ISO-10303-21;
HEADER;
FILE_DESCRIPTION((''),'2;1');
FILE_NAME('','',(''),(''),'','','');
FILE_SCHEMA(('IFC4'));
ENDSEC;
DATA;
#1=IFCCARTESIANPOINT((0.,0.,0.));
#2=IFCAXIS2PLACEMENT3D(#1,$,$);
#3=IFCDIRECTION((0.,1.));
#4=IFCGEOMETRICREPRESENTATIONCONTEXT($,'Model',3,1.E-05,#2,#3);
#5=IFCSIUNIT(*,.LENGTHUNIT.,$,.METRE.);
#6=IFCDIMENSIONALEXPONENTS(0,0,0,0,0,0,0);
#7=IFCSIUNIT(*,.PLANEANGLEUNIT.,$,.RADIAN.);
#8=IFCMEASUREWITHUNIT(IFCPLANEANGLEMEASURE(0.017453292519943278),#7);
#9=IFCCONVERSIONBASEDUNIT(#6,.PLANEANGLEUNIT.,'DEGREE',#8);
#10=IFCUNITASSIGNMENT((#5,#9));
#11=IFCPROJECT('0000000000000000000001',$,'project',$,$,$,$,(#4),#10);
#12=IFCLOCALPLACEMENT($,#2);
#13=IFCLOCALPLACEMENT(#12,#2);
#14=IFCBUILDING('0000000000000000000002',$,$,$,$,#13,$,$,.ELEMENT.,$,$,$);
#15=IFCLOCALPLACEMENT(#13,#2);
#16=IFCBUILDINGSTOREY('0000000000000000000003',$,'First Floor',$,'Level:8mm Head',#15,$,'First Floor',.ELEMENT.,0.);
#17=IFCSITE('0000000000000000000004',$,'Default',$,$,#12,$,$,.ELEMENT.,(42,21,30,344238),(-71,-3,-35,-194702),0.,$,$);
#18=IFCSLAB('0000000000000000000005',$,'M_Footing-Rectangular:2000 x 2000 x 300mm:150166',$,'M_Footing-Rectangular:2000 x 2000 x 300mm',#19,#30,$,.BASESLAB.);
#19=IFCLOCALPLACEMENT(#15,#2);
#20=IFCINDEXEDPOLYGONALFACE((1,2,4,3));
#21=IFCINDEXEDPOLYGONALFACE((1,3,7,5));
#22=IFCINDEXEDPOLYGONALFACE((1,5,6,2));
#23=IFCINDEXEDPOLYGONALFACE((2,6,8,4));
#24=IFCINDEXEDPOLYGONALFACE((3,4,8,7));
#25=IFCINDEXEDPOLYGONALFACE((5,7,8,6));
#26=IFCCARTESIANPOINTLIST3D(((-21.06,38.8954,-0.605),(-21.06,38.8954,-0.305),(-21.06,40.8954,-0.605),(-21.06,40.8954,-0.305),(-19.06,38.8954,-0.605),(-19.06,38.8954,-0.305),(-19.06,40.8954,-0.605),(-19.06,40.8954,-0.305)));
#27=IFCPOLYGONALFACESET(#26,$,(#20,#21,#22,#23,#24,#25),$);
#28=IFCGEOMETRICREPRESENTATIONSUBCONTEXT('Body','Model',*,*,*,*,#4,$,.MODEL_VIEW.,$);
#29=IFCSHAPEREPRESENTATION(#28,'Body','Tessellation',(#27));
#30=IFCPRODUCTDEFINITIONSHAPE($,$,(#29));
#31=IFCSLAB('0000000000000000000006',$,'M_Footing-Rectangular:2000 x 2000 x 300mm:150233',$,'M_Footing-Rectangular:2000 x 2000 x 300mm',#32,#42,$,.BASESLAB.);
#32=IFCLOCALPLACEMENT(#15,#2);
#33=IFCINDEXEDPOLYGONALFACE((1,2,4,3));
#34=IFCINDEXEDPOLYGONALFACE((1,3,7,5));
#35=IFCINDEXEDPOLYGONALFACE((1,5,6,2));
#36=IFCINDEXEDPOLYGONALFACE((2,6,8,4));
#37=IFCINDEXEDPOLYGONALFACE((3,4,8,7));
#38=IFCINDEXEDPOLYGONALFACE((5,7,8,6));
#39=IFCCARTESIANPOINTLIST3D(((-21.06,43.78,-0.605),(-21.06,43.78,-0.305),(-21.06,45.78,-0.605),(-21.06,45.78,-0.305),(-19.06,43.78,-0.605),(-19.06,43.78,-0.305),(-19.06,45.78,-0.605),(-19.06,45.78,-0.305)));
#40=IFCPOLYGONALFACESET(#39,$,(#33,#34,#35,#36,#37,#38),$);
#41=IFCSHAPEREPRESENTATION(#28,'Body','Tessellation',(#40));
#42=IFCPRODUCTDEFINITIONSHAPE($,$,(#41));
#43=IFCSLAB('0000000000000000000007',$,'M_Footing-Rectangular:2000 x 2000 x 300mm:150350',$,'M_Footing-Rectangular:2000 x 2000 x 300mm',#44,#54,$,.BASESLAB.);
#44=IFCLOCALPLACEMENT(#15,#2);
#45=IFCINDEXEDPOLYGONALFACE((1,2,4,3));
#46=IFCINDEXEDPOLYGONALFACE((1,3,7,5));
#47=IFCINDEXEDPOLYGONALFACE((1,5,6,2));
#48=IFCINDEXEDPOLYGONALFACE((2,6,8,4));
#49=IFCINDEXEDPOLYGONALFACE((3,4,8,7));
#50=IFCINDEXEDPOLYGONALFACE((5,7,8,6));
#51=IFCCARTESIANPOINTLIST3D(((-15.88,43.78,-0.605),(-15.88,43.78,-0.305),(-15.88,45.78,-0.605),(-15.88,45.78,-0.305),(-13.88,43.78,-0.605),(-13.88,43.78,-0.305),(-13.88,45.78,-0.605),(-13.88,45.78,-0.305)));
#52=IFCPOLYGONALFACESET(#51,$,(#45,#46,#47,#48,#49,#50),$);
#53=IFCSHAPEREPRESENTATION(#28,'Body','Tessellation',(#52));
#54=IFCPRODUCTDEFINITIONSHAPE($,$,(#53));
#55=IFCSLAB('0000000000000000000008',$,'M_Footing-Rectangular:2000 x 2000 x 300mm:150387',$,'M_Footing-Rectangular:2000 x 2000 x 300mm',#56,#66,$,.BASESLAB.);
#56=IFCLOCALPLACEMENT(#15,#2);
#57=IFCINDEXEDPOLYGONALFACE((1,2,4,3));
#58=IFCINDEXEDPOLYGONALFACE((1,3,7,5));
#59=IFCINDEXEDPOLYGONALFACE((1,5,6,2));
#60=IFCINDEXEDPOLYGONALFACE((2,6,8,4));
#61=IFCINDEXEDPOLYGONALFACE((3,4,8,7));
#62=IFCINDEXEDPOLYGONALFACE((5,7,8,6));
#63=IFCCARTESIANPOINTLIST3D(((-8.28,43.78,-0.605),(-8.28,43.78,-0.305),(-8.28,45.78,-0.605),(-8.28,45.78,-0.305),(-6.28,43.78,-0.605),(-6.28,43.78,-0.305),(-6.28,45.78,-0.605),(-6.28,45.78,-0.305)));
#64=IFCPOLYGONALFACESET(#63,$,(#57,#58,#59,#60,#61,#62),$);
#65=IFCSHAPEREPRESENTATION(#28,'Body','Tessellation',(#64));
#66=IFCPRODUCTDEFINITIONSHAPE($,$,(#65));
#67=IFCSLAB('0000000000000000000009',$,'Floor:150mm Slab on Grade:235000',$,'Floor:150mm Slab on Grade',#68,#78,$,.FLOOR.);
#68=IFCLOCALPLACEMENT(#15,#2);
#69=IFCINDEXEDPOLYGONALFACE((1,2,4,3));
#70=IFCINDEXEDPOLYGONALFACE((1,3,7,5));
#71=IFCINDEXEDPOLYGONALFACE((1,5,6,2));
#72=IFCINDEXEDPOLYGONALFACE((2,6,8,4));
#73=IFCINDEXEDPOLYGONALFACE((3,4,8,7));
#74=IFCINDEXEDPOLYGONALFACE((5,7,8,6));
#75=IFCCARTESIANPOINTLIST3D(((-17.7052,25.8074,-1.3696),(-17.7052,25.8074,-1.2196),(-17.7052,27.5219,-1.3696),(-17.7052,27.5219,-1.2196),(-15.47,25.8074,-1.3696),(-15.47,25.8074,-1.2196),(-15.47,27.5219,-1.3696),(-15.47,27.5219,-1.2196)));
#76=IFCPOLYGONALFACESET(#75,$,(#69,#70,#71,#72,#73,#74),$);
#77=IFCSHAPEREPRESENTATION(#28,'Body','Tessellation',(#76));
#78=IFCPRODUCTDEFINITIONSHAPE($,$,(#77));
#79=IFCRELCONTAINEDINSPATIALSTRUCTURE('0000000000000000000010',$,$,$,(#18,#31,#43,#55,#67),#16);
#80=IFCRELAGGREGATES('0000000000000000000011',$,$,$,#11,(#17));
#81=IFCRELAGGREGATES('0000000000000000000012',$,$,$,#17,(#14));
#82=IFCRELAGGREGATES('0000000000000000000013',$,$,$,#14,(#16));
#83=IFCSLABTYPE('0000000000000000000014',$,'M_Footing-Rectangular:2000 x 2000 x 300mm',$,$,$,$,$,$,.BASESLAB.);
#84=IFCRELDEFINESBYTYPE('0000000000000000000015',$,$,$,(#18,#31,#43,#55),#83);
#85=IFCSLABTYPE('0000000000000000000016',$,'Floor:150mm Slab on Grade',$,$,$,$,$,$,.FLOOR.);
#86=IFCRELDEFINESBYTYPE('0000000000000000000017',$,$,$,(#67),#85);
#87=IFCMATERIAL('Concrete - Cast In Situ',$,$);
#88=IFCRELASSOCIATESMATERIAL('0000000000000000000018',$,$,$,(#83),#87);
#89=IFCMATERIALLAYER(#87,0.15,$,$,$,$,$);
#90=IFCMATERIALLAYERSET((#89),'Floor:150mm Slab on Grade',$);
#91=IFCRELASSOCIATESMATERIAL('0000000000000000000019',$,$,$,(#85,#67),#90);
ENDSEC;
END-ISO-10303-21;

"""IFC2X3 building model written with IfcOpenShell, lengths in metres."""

from ifc_helpers import new_model, entity, si_unit, converted_unit, direction, frame, frame_2d, origin, origin_2d_with_axis, place, context, subcontext, project, spatial, rectangle, extrude, material, layer, layer_set, layer_usage, type_object, element, save


model = new_model("IFC2X3")

# Units and contexts
model_context = context("Model", 3, precision=1e-05, world=origin(), true_north=direction((0.0, 1.0)))
body_context = subcontext(model_context, "Body", "Model", "MODEL_VIEW")
ifc_project = project(units=[si_unit("LENGTHUNIT", "METRE"), converted_unit("PLANEANGLEUNIT", "DEGREE", entity("IfcPlaneAngleMeasure", 0.017453292519943278), si_unit("PLANEANGLEUNIT", "RADIAN"), dimensions=[0, 0, 0, 0, 0, 0, 0])], contexts=[model_context])

# Site, building, storey
site_placement = place(None, origin())
site = spatial("IfcSite", under=ifc_project, at=site_placement, Name="Default", CompositionType="ELEMENT", RefLatitude=(42, 21, 30, 344238), RefLongitude=(-71, -3, -35, -194702), RefElevation=0.0)
building_placement = place(site_placement, origin())
building = spatial("IfcBuilding", under=site, at=building_placement, CompositionType="ELEMENT")
storey_placement = place(building_placement, origin())
storey = spatial("IfcBuildingStorey", under=building, at=storey_placement, Name="First Floor", ObjectType="Level:8mm Head", LongName="First Floor", CompositionType="ELEMENT", Elevation=0.0)

# Slabs
ifc_material = material(Name="Concrete - Cast In Situ")
slab_type_1 = type_object("IfcSlabType", Name="M_Footing-Rectangular:2000 x 2000 x 300mm", PredefinedType="BASESLAB", material=ifc_material)
slab_1_placement = place(storey_placement, origin())
element("IfcSlab", 1, at=slab_1_placement, inside=storey, type_object=slab_type_1, Name="M_Footing-Rectangular:2000 x 2000 x 300mm:150166", ObjectType="M_Footing-Rectangular:2000 x 2000 x 300mm", PredefinedType="BASESLAB", context=body_context, shape_type="SweptSolid", body=[
    extrude(rectangle(XDim=2.0, YDim=2.0, at=frame_2d((0.0, 0.0), x_axis=(1.0, 0.0))), frame((-20.06, 39.8954, -0.605), z_axis=(0.0, 0.0, 1.0), x_axis=(-1.0, 0.0, 0.0)), (0.0, 0.0, 1.0), 0.3),
])
slab_2_placement = place(storey_placement, origin())
element("IfcSlab", 2, at=slab_2_placement, inside=storey, type_object=slab_type_1, Name="M_Footing-Rectangular:2000 x 2000 x 300mm:150233", ObjectType="M_Footing-Rectangular:2000 x 2000 x 300mm", PredefinedType="BASESLAB", context=body_context, shape_type="SweptSolid", body=[
    extrude(rectangle(XDim=2.0, YDim=2.0, at=frame_2d((0.0, 0.0), x_axis=(1.0, 0.0))), frame((-20.06, 44.78, -0.605), z_axis=(0.0, 0.0, 1.0), x_axis=(-1.0, 0.0, 0.0)), (0.0, 0.0, 1.0), 0.3),
])
slab_3_placement = place(storey_placement, origin())
element("IfcSlab", 3, at=slab_3_placement, inside=storey, type_object=slab_type_1, Name="M_Footing-Rectangular:2000 x 2000 x 300mm:150350", ObjectType="M_Footing-Rectangular:2000 x 2000 x 300mm", PredefinedType="BASESLAB", context=body_context, shape_type="SweptSolid", body=[
    extrude(rectangle(XDim=2.0, YDim=2.0, at=origin_2d_with_axis()), frame((-14.88, 44.78, -0.605), z_axis=(0.0, 0.0, 1.0), x_axis=(-1.0, 0.0, 0.0)), (0.0, 0.0, 1.0), 0.3),
])
slab_4_placement = place(storey_placement, origin())
element("IfcSlab", 4, at=slab_4_placement, inside=storey, type_object=slab_type_1, Name="M_Footing-Rectangular:2000 x 2000 x 300mm:150387", ObjectType="M_Footing-Rectangular:2000 x 2000 x 300mm", PredefinedType="BASESLAB", context=body_context, shape_type="SweptSolid", body=[
    extrude(rectangle(XDim=2.0, YDim=2.0, at=frame_2d((0.0, 0.0), x_axis=(1.0, 0.0))), frame((-7.28, 44.78, -0.605), z_axis=(0.0, 0.0, 1.0), x_axis=(-1.0, 0.0, 0.0)), (0.0, 0.0, 1.0), 0.3),
])

# Shared definitions
ifc_layer_1 = layer(ifc_material, 0.15)
ifc_layer_set_1 = layer_set([ifc_layer_1], Name="Floor:150mm Slab on Grade")
slab_type_2 = type_object("IfcSlabType", Name="Floor:150mm Slab on Grade", PredefinedType="FLOOR", material=ifc_layer_set_1)

# Slab
ifc_layer_usage_1 = layer_usage(ifc_layer_set_1, "AXIS3", "POSITIVE", 0.0)
slab_5_placement = place(storey_placement, origin())
element("IfcSlab", 5, at=slab_5_placement, inside=storey, type_object=slab_type_2, material=ifc_layer_usage_1, Name="Floor:150mm Slab on Grade:235000", ObjectType="Floor:150mm Slab on Grade", PredefinedType="FLOOR", context=body_context, shape_type="SweptSolid", body=[
    extrude(rectangle(XDim=1.7145, YDim=2.2352, at=origin_2d_with_axis()), frame((-16.5876, 26.6646, -1.2196), z_axis=(0.0, 0.0, -1.0), x_axis=(0.0, 1.0, 0.0)), (0.0, 0.0, 1.0), 0.15),
])

save(model, "model.ifc")
